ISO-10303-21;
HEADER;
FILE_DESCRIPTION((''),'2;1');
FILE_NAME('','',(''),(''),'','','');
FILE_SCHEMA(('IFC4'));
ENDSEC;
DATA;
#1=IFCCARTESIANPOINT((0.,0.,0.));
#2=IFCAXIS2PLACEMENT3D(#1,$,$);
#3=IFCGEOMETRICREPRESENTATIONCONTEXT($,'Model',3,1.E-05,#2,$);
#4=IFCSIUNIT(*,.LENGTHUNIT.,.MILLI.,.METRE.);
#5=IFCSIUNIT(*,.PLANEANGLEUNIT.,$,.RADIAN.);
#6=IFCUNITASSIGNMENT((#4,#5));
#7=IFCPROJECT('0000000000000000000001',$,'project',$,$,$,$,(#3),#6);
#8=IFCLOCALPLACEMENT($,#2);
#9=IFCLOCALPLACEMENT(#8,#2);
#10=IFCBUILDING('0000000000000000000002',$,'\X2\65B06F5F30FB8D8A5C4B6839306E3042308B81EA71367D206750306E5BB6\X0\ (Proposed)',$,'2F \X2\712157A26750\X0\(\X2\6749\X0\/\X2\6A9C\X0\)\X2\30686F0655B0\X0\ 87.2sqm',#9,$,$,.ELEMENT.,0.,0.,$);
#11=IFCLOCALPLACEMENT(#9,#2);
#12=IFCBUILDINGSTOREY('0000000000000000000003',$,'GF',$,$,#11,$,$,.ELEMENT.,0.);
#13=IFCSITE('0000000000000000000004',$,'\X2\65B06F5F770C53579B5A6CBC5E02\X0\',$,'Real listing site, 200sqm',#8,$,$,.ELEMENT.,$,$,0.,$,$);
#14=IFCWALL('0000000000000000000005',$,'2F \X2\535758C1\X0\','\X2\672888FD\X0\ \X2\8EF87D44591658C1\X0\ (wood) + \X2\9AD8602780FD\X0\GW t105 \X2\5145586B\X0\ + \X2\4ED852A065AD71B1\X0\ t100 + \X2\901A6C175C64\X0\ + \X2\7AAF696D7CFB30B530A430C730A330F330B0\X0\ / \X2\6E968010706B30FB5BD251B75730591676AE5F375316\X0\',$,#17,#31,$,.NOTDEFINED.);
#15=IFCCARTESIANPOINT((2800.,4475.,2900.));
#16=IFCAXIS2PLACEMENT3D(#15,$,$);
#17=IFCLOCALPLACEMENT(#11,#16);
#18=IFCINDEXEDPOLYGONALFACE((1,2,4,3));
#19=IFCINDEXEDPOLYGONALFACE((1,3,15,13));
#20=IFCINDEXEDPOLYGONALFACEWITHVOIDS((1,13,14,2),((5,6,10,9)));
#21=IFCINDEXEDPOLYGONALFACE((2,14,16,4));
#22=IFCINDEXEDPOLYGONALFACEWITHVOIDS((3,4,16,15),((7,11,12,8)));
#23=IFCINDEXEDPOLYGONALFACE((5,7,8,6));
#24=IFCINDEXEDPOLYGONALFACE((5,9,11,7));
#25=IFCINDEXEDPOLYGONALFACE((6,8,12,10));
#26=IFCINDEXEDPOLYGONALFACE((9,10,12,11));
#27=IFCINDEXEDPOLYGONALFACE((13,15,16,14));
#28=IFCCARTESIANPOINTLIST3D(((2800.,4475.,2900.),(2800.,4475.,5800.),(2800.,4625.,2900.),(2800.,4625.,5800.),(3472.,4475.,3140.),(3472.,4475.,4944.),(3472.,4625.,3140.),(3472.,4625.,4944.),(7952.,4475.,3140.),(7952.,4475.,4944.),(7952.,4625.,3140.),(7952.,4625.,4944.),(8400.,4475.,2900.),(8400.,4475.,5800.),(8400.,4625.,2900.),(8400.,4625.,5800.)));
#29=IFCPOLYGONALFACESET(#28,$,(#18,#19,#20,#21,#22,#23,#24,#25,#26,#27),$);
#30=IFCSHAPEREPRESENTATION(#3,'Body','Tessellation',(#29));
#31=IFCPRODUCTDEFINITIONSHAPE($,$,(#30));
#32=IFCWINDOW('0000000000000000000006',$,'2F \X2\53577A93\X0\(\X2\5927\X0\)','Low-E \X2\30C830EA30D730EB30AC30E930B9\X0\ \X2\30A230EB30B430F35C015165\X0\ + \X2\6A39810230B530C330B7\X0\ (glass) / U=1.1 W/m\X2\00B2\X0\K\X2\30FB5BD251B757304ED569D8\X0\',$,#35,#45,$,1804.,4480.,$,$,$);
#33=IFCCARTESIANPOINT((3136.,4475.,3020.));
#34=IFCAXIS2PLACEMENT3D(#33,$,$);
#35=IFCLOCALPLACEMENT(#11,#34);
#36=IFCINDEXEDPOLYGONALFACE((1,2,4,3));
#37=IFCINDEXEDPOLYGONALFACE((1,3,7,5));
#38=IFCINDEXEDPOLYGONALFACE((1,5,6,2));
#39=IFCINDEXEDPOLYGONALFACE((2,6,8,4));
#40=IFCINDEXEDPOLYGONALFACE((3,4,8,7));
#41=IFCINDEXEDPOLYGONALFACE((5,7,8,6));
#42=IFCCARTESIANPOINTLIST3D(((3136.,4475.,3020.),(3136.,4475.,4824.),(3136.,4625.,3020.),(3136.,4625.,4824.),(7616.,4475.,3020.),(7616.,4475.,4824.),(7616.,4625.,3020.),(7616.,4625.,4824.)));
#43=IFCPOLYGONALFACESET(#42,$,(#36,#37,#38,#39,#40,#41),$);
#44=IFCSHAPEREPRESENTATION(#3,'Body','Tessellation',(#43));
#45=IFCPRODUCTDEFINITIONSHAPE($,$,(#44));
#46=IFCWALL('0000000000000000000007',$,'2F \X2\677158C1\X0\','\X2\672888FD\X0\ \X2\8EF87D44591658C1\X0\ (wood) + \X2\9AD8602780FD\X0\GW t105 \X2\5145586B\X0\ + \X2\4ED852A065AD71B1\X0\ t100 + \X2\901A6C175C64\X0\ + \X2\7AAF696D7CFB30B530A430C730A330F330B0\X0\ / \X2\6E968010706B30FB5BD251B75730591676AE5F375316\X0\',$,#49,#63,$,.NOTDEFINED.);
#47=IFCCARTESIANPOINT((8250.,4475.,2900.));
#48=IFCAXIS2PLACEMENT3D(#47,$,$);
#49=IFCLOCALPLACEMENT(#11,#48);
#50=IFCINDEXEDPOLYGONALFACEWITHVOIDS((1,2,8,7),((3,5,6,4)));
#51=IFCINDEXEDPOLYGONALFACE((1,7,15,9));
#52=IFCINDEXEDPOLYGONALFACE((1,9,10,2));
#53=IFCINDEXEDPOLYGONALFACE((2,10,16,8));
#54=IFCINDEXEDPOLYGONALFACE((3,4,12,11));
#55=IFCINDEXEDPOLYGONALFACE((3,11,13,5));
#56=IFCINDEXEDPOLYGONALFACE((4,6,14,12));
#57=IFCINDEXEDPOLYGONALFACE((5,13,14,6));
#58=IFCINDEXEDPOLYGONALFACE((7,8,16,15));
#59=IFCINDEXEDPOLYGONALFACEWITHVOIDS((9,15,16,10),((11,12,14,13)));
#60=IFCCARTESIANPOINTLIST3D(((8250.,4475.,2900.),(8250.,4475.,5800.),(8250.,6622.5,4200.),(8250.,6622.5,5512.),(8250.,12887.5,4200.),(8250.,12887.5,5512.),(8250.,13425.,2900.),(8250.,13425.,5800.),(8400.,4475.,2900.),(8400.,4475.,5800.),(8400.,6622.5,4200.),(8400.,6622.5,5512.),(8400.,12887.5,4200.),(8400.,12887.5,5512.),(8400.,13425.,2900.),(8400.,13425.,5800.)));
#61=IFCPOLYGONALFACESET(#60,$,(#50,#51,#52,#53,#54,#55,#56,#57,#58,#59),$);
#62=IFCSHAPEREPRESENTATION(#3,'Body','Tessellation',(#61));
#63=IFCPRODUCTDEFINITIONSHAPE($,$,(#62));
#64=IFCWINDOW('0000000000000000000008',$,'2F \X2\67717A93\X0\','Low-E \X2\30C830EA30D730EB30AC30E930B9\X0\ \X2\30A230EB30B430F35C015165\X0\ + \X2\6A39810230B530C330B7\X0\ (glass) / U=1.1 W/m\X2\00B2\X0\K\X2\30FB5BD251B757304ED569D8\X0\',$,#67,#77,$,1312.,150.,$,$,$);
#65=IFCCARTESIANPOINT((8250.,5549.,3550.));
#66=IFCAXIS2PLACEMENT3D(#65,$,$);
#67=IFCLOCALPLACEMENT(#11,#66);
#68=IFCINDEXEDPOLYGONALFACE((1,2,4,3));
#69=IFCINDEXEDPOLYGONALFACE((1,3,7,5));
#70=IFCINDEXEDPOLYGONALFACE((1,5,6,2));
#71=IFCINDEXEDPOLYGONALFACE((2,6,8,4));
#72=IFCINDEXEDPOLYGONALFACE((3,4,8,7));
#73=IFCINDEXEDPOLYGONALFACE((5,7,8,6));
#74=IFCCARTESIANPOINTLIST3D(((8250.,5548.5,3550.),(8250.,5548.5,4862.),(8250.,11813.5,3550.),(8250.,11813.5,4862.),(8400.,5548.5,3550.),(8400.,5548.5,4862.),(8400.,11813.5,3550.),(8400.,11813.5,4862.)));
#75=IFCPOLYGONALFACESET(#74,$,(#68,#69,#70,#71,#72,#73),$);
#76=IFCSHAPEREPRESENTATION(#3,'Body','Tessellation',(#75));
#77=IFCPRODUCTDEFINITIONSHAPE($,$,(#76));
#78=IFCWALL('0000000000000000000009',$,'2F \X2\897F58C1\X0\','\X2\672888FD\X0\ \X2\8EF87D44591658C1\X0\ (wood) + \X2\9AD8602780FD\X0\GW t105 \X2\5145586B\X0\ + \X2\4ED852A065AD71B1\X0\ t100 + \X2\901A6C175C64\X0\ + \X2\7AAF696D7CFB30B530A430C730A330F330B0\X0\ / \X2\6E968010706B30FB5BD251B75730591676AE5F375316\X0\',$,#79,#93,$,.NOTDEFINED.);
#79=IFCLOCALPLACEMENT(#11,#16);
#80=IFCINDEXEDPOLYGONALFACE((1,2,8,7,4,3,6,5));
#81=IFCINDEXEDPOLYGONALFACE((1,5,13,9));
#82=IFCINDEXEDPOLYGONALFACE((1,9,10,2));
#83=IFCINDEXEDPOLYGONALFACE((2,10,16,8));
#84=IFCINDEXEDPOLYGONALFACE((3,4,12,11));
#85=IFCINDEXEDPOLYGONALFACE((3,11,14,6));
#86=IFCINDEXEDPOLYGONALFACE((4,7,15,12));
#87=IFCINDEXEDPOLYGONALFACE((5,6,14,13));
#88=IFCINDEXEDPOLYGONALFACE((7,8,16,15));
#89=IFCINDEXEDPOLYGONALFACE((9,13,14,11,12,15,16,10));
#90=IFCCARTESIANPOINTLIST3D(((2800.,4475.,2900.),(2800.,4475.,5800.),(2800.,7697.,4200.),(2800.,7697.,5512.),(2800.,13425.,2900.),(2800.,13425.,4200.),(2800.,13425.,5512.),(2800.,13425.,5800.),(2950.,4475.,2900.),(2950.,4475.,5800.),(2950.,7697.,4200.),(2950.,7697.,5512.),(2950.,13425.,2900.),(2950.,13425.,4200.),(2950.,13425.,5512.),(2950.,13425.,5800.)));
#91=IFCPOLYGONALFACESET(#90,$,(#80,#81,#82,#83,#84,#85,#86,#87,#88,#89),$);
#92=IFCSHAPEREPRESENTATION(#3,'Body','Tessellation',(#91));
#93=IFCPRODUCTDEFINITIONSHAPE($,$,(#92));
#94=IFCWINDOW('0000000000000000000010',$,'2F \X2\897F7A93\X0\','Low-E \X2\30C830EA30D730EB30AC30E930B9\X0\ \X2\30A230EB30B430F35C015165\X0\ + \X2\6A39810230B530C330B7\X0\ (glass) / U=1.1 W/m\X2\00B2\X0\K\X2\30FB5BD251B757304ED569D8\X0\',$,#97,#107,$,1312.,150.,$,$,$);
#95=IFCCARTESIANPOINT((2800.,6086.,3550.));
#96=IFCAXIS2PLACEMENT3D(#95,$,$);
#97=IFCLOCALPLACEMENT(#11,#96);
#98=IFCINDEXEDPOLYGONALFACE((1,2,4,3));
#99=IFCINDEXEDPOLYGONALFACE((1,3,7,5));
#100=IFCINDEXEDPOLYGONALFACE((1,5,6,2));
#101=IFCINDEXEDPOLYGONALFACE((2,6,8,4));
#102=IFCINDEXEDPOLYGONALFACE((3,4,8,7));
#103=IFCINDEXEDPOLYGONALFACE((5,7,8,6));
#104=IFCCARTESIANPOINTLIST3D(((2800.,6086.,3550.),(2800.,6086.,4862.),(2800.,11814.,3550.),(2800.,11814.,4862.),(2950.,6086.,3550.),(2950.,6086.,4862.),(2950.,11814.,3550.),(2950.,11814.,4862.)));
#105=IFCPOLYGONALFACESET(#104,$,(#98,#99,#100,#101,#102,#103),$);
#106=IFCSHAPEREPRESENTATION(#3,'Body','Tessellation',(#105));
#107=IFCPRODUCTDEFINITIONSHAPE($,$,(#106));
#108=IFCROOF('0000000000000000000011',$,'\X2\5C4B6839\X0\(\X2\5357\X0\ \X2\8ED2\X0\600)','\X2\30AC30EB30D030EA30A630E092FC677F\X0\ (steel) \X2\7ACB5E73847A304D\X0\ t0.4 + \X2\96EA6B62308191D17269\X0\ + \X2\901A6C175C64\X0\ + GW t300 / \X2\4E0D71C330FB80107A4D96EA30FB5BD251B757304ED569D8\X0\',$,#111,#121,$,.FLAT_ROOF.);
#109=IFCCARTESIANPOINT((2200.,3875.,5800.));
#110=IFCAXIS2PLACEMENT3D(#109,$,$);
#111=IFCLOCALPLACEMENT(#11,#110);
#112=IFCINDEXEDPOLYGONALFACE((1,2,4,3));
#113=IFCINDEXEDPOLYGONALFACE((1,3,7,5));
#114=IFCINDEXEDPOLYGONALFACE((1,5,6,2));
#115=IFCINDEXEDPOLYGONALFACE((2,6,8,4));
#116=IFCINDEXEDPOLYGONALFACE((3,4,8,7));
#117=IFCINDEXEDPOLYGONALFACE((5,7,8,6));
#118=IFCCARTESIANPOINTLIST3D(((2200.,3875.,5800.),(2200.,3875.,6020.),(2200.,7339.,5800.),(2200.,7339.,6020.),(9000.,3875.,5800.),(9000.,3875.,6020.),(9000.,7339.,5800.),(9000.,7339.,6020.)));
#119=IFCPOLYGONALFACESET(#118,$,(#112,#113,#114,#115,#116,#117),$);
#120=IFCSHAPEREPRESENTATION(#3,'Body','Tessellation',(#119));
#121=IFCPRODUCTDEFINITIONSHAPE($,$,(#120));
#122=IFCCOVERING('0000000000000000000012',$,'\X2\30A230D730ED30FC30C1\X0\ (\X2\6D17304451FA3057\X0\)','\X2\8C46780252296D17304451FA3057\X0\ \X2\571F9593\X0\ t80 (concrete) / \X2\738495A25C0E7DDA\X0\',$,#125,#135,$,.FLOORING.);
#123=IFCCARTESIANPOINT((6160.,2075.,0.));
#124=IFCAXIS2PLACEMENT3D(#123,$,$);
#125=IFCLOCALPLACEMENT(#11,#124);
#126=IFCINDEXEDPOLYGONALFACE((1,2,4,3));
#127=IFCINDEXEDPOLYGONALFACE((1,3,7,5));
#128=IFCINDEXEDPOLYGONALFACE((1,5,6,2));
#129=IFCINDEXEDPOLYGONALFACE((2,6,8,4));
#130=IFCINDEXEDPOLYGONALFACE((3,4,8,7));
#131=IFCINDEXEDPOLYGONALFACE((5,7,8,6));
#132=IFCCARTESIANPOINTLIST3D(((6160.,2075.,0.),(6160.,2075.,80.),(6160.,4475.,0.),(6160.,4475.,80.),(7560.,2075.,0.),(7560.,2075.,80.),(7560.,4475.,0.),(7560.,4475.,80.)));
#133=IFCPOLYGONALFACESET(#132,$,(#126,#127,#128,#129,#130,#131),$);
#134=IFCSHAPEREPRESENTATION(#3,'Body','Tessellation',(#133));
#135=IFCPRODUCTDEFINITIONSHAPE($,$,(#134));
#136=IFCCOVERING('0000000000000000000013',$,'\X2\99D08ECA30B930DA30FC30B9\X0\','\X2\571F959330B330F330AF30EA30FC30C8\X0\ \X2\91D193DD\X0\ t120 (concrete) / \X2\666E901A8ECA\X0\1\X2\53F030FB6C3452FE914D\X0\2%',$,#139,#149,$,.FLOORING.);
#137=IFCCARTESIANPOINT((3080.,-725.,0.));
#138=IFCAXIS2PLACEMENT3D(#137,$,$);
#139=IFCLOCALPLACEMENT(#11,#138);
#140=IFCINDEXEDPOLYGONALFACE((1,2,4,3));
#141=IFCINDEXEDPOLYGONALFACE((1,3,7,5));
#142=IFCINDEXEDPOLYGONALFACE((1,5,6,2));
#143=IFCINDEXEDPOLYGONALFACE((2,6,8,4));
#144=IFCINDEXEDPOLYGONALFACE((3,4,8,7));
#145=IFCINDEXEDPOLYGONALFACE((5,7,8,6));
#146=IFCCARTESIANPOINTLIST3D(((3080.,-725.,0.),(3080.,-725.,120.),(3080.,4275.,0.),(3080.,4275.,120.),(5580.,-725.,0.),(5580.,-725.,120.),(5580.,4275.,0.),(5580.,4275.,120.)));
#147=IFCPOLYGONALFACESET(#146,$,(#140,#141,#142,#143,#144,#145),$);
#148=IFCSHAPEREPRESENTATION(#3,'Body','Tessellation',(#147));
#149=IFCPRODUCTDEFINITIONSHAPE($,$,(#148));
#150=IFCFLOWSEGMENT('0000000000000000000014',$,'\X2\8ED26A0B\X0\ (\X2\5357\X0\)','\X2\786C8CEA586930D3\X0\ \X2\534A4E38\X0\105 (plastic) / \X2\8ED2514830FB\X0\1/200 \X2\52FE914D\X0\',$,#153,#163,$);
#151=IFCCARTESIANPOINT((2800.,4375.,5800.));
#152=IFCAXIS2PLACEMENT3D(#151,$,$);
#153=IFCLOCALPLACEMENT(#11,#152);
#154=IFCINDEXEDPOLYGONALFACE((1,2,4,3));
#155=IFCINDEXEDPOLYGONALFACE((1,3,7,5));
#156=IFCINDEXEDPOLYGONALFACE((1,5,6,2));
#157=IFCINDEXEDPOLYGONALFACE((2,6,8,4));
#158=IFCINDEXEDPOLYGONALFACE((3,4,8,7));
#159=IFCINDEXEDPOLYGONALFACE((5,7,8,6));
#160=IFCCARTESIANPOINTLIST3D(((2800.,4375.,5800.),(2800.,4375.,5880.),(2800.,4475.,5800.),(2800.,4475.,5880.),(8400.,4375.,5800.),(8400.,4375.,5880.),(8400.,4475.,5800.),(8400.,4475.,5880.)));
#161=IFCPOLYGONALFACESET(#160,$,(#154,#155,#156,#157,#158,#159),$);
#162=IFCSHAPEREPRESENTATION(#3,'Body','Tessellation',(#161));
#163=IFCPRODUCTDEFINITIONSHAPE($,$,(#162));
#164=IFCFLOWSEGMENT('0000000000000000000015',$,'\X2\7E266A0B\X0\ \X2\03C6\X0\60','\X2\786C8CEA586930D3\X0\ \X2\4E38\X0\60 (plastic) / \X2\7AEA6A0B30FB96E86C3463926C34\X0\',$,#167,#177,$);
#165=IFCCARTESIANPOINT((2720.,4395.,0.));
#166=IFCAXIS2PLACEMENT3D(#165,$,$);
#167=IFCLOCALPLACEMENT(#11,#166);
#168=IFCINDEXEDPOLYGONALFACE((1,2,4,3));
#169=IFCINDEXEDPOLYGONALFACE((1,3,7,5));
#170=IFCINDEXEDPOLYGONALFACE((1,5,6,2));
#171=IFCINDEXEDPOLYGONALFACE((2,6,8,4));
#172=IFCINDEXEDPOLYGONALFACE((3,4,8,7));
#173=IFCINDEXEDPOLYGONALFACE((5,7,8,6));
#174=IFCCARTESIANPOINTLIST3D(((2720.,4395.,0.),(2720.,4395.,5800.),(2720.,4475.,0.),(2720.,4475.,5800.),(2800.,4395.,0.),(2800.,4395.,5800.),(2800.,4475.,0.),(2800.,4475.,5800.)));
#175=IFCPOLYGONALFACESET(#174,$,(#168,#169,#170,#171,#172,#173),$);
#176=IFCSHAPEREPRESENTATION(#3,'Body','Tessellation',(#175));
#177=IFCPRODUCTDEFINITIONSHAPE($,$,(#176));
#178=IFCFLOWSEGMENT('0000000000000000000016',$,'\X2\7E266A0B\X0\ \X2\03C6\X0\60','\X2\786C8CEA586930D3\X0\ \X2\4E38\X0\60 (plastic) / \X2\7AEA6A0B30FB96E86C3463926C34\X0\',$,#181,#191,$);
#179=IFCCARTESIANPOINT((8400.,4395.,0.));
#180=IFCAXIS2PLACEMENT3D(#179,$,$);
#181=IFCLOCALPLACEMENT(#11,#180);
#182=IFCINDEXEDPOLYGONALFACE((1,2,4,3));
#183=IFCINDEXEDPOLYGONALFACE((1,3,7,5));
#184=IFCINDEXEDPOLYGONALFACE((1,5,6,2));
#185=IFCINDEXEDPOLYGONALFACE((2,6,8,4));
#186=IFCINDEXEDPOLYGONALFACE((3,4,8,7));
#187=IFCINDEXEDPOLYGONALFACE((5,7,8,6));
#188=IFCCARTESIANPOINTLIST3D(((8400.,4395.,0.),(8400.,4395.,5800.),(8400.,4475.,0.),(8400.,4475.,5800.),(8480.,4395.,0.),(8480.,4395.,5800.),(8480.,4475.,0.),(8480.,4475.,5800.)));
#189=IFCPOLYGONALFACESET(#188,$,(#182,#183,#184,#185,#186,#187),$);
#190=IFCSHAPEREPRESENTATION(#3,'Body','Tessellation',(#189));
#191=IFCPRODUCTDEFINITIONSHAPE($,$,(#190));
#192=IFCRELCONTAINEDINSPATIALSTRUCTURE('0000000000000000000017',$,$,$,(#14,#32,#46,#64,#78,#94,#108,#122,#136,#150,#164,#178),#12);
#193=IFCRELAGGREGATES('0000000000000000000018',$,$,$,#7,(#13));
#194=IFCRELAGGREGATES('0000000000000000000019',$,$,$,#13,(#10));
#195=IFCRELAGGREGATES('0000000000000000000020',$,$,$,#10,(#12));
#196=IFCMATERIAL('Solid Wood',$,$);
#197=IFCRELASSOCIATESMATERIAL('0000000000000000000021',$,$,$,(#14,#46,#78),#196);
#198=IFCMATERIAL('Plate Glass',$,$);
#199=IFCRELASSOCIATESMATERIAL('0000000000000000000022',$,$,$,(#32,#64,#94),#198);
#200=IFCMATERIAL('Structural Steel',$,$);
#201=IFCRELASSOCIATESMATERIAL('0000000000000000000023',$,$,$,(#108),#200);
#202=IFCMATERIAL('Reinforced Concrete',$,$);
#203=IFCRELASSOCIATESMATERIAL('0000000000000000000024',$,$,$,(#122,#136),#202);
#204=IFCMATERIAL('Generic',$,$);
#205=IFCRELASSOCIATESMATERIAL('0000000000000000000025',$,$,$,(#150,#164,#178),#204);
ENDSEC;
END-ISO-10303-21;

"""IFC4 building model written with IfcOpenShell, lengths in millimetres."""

from ifc_helpers import new_model, si_unit, frame, frame_2d, origin, place, context, project, spatial, rectangle, extrude, material, element, fill, save


model = new_model("IFC4")

# Units and contexts
model_context = context("Model", 3, precision=1e-05, world=origin())
ifc_project = project(units=[si_unit("LENGTHUNIT", "METRE", prefix="MILLI"), si_unit("PLANEANGLEUNIT", "RADIAN")], contexts=[model_context])

# Site, building, storey
site_placement = place(None, origin())
site = spatial("IfcSite", under=ifc_project, at=site_placement, Name="新潟県南魚沼市", ObjectType="Real listing site, 200sqm", CompositionType="ELEMENT", RefElevation=0.0)
building_placement = place(site_placement, origin())
building = spatial("IfcBuilding", under=site, at=building_placement, Name="新潟・越屋根のある自然素材の家 (Proposed)", ObjectType="2F 無垢材(杉/檜)と漆喰 87.2sqm", CompositionType="ELEMENT", ElevationOfRefHeight=0.0, ElevationOfTerrain=0.0)
storey_placement = place(building_placement, origin())
storey = spatial("IfcBuildingStorey", under=building, at=storey_placement, Name="GF", CompositionType="ELEMENT", Elevation=0.0)

# Shared definitions
ifc_material_1 = material(Name="Solid Wood")

# Shared definitions
ifc_material_2 = material(Name="Reinforced Concrete")

# Shared definitions
ifc_material_3 = material(Name="Plate Glass")

# Walls, openings, windows
wall_1_placement = place(storey_placement, frame((2800.0, 4475.0, 2900.0)))
wall_1 = element("IfcWall", 1, at=wall_1_placement, inside=storey, material=ifc_material_1, Name="2F 南壁", Description="木製 軸組外壁 (wood) + 高性能GW t105 充填 + 付加断熱 t100 + 通気層 + 窯業系サイディング / 準耐火・寒冷地外皮強化", PredefinedType="NOTDEFINED", context=model_context, shape_type="SweptSolid", body=[
    extrude(rectangle(XDim=5600.0, YDim=150.0, at=frame_2d((2800.0, 75.0))), frame((2800.0, 4475.0, 2900.0)), (0.0, 0.0, 1.0), 2900.0),
])
opening_1_placement = place(storey_placement, frame((3136.0, 4475.0, 3020.0)))
opening_1 = element("IfcOpeningElement", 2, at=opening_1_placement, cuts=wall_1, PredefinedType="NOTDEFINED", context=model_context, shape_type="SweptSolid", body=[
    extrude(rectangle(XDim=4480.0, YDim=150.0, at=frame_2d((2240.0, 75.0))), frame((3136.0, 4475.0, 3020.0)), (0.0, 0.0, 1.0), 1804.0),
])
window_1_placement = place(storey_placement, frame((3136.0, 4475.0, 3020.0)))
window_1 = element("IfcWindow", 3, at=window_1_placement, inside=storey, material=ifc_material_3, Name="2F 南窓(大)", Description="Low-E トリプルガラス アルゴン封入 + 樹脂サッシ (glass) / U=1.1 W/m²K・寒冷地仕様", OverallHeight=1804.0, OverallWidth=4480.0, context=model_context, shape_type="SweptSolid", body=[
    extrude(rectangle(XDim=4480.0, YDim=150.0, at=frame_2d((2240.0, 75.0))), frame((3136.0, 4475.0, 3020.0)), (0.0, 0.0, 1.0), 1804.0),
])
fill(opening_1, window_1)
wall_2_placement = place(storey_placement, frame((8250.0, 4475.0, 2900.0)))
wall_2 = element("IfcWall", 4, at=wall_2_placement, inside=storey, material=ifc_material_1, Name="2F 東壁", Description="木製 軸組外壁 (wood) + 高性能GW t105 充填 + 付加断熱 t100 + 通気層 + 窯業系サイディング / 準耐火・寒冷地外皮強化", PredefinedType="NOTDEFINED", context=model_context, shape_type="SweptSolid", body=[
    extrude(rectangle(XDim=150.0, YDim=8950.0, at=frame_2d((75.0, 4475.0))), frame((8250.0, 4475.0, 2900.0)), (0.0, 0.0, 1.0), 2900.0),
])
opening_2_placement = place(storey_placement, frame((8250.0, 5549.0, 3550.0)))
opening_2 = element("IfcOpeningElement", 5, at=opening_2_placement, cuts=wall_2, PredefinedType="NOTDEFINED", context=model_context, shape_type="SweptSolid", body=[
    extrude(rectangle(XDim=150.0, YDim=6265.0, at=frame_2d((75.0, 3132.0))), frame((8250.0, 5549.0, 3550.0)), (0.0, 0.0, 1.0), 1312.0),
])
window_2_placement = place(storey_placement, frame((8250.0, 5549.0, 3550.0)))
window_2 = element("IfcWindow", 6, at=window_2_placement, inside=storey, material=ifc_material_3, Name="2F 東窓", Description="Low-E トリプルガラス アルゴン封入 + 樹脂サッシ (glass) / U=1.1 W/m²K・寒冷地仕様", OverallHeight=1312.0, OverallWidth=150.0, context=model_context, shape_type="SweptSolid", body=[
    extrude(rectangle(XDim=150.0, YDim=6265.0, at=frame_2d((75.0, 3132.0))), frame((8250.0, 5549.0, 3550.0)), (0.0, 0.0, 1.0), 1312.0),
])
fill(opening_2, window_2)
wall_3_placement = place(storey_placement, frame((2800.0, 4475.0, 2900.0)))
wall_3 = element("IfcWall", 7, at=wall_3_placement, inside=storey, material=ifc_material_1, Name="2F 西壁", Description="木製 軸組外壁 (wood) + 高性能GW t105 充填 + 付加断熱 t100 + 通気層 + 窯業系サイディング / 準耐火・寒冷地外皮強化", PredefinedType="NOTDEFINED", context=model_context, shape_type="SweptSolid", body=[
    extrude(rectangle(XDim=150.0, YDim=8950.0, at=frame_2d((75.0, 4475.0))), frame((2800.0, 4475.0, 2900.0)), (0.0, 0.0, 1.0), 2900.0),
])
opening_3_placement = place(storey_placement, frame((2800.0, 6086.0, 3550.0)))
opening_3 = element("IfcOpeningElement", 8, at=opening_3_placement, cuts=wall_3, PredefinedType="NOTDEFINED", context=model_context, shape_type="SweptSolid", body=[
    extrude(rectangle(XDim=150.0, YDim=5728.0, at=frame_2d((75.0, 2864.0))), frame((2800.0, 6086.0, 3550.0)), (0.0, 0.0, 1.0), 1312.0),
])
window_3_placement = place(storey_placement, frame((2800.0, 6086.0, 3550.0)))
window_3 = element("IfcWindow", 9, at=window_3_placement, inside=storey, material=ifc_material_3, Name="2F 西窓", Description="Low-E トリプルガラス アルゴン封入 + 樹脂サッシ (glass) / U=1.1 W/m²K・寒冷地仕様", OverallHeight=1312.0, OverallWidth=150.0, context=model_context, shape_type="SweptSolid", body=[
    extrude(rectangle(XDim=150.0, YDim=5728.0, at=frame_2d((75.0, 2864.0))), frame((2800.0, 6086.0, 3550.0)), (0.0, 0.0, 1.0), 1312.0),
])
fill(opening_3, window_3)

# Roof
ifc_material_4 = material(Name="Structural Steel")
for number, where, name in (
    (10, (2200.0, 3875.0, 5800.0), "屋根(南 軒600)"),
):
    element("IfcRoof", number, at=place(storey_placement, frame(where)), inside=storey, material=ifc_material_4, Name=name, Description="ガルバリウム鋼板 (steel) 立平葺き t0.4 + 雪止め金物 + 通気層 + GW t300 / 不燃・耐積雪・寒冷地仕様", PredefinedType="FLAT_ROOF", context=model_context, shape_type="SweptSolid", body=[
        extrude(rectangle(XDim=6800.0, YDim=3464.0, at=frame_2d((3400.0, 1732.0))), frame((2200.0, 3875.0, 5800.0)), (0.0, 0.0, 1.0), 220.0),
    ])

# Coverings
covering_1_placement = place(storey_placement, frame((6160.0, 2075.0, 0.0)))
element("IfcCovering", 11, at=covering_1_placement, inside=storey, material=ifc_material_2, Name="アプローチ (洗い出し)", Description="豆砂利洗い出し 土間 t80 (concrete) / 玄関導線", PredefinedType="FLOORING", context=model_context, shape_type="SweptSolid", body=[
    extrude(rectangle(XDim=1400.0, YDim=2400.0, at=frame_2d((700.0, 1200.0))), frame((6160.0, 2075.0, 0.0)), (0.0, 0.0, 1.0), 80.0),
])
covering_2_placement = place(storey_placement, frame((3080.0, -725.0, 0.0)))
element("IfcCovering", 12, at=covering_2_placement, inside=storey, material=ifc_material_2, Name="駐車スペース", Description="土間コンクリート 金鏝 t120 (concrete) / 普通車1台・水勾配2%", PredefinedType="FLOORING", context=model_context, shape_type="SweptSolid", body=[
    extrude(rectangle(XDim=2500.0, YDim=5000.0, at=frame_2d((1250.0, 2500.0))), frame((3080.0, -725.0, 0.0)), (0.0, 0.0, 1.0), 120.0),
])

# Flow segments
ifc_material_5 = material(Name="Generic")
flow_segment_1_placement = place(storey_placement, frame((2800.0, 4375.0, 5800.0)))
element("IfcFlowSegment", 13, at=flow_segment_1_placement, inside=storey, material=ifc_material_5, Name="軒樋 (南)", Description="硬質塩ビ 半丸105 (plastic) / 軒先・1/200 勾配", context=model_context, shape_type="SweptSolid", body=[
    extrude(rectangle(XDim=5600.0, YDim=100.0, at=frame_2d((2800.0, 50.0))), frame((2800.0, 4375.0, 5800.0)), (0.0, 0.0, 1.0), 80.0),
])
flow_segment_2_placement = place(storey_placement, frame((2720.0, 4395.0, 0.0)))
element("IfcFlowSegment", 14, at=flow_segment_2_placement, inside=storey, material=ifc_material_5, Name="縦樋 φ60", Description="硬質塩ビ 丸60 (plastic) / 竪樋・雨水排水", context=model_context, shape_type="SweptSolid", body=[
    extrude(rectangle(XDim=80.0, YDim=80.0, at=frame_2d((40.0, 40.0))), frame((2720.0, 4395.0, 0.0)), (0.0, 0.0, 1.0), 5800.0),
])
flow_segment_3_placement = place(storey_placement, frame((8400.0, 4395.0, 0.0)))
element("IfcFlowSegment", 15, at=flow_segment_3_placement, inside=storey, material=ifc_material_5, Name="縦樋 φ60", Description="硬質塩ビ 丸60 (plastic) / 竪樋・雨水排水", context=model_context, shape_type="SweptSolid", body=[
    extrude(rectangle(XDim=80.0, YDim=80.0, at=frame_2d((40.0, 40.0))), frame((8400.0, 4395.0, 0.0)), (0.0, 0.0, 1.0), 5800.0),
])

save(model, "model.ifc")
